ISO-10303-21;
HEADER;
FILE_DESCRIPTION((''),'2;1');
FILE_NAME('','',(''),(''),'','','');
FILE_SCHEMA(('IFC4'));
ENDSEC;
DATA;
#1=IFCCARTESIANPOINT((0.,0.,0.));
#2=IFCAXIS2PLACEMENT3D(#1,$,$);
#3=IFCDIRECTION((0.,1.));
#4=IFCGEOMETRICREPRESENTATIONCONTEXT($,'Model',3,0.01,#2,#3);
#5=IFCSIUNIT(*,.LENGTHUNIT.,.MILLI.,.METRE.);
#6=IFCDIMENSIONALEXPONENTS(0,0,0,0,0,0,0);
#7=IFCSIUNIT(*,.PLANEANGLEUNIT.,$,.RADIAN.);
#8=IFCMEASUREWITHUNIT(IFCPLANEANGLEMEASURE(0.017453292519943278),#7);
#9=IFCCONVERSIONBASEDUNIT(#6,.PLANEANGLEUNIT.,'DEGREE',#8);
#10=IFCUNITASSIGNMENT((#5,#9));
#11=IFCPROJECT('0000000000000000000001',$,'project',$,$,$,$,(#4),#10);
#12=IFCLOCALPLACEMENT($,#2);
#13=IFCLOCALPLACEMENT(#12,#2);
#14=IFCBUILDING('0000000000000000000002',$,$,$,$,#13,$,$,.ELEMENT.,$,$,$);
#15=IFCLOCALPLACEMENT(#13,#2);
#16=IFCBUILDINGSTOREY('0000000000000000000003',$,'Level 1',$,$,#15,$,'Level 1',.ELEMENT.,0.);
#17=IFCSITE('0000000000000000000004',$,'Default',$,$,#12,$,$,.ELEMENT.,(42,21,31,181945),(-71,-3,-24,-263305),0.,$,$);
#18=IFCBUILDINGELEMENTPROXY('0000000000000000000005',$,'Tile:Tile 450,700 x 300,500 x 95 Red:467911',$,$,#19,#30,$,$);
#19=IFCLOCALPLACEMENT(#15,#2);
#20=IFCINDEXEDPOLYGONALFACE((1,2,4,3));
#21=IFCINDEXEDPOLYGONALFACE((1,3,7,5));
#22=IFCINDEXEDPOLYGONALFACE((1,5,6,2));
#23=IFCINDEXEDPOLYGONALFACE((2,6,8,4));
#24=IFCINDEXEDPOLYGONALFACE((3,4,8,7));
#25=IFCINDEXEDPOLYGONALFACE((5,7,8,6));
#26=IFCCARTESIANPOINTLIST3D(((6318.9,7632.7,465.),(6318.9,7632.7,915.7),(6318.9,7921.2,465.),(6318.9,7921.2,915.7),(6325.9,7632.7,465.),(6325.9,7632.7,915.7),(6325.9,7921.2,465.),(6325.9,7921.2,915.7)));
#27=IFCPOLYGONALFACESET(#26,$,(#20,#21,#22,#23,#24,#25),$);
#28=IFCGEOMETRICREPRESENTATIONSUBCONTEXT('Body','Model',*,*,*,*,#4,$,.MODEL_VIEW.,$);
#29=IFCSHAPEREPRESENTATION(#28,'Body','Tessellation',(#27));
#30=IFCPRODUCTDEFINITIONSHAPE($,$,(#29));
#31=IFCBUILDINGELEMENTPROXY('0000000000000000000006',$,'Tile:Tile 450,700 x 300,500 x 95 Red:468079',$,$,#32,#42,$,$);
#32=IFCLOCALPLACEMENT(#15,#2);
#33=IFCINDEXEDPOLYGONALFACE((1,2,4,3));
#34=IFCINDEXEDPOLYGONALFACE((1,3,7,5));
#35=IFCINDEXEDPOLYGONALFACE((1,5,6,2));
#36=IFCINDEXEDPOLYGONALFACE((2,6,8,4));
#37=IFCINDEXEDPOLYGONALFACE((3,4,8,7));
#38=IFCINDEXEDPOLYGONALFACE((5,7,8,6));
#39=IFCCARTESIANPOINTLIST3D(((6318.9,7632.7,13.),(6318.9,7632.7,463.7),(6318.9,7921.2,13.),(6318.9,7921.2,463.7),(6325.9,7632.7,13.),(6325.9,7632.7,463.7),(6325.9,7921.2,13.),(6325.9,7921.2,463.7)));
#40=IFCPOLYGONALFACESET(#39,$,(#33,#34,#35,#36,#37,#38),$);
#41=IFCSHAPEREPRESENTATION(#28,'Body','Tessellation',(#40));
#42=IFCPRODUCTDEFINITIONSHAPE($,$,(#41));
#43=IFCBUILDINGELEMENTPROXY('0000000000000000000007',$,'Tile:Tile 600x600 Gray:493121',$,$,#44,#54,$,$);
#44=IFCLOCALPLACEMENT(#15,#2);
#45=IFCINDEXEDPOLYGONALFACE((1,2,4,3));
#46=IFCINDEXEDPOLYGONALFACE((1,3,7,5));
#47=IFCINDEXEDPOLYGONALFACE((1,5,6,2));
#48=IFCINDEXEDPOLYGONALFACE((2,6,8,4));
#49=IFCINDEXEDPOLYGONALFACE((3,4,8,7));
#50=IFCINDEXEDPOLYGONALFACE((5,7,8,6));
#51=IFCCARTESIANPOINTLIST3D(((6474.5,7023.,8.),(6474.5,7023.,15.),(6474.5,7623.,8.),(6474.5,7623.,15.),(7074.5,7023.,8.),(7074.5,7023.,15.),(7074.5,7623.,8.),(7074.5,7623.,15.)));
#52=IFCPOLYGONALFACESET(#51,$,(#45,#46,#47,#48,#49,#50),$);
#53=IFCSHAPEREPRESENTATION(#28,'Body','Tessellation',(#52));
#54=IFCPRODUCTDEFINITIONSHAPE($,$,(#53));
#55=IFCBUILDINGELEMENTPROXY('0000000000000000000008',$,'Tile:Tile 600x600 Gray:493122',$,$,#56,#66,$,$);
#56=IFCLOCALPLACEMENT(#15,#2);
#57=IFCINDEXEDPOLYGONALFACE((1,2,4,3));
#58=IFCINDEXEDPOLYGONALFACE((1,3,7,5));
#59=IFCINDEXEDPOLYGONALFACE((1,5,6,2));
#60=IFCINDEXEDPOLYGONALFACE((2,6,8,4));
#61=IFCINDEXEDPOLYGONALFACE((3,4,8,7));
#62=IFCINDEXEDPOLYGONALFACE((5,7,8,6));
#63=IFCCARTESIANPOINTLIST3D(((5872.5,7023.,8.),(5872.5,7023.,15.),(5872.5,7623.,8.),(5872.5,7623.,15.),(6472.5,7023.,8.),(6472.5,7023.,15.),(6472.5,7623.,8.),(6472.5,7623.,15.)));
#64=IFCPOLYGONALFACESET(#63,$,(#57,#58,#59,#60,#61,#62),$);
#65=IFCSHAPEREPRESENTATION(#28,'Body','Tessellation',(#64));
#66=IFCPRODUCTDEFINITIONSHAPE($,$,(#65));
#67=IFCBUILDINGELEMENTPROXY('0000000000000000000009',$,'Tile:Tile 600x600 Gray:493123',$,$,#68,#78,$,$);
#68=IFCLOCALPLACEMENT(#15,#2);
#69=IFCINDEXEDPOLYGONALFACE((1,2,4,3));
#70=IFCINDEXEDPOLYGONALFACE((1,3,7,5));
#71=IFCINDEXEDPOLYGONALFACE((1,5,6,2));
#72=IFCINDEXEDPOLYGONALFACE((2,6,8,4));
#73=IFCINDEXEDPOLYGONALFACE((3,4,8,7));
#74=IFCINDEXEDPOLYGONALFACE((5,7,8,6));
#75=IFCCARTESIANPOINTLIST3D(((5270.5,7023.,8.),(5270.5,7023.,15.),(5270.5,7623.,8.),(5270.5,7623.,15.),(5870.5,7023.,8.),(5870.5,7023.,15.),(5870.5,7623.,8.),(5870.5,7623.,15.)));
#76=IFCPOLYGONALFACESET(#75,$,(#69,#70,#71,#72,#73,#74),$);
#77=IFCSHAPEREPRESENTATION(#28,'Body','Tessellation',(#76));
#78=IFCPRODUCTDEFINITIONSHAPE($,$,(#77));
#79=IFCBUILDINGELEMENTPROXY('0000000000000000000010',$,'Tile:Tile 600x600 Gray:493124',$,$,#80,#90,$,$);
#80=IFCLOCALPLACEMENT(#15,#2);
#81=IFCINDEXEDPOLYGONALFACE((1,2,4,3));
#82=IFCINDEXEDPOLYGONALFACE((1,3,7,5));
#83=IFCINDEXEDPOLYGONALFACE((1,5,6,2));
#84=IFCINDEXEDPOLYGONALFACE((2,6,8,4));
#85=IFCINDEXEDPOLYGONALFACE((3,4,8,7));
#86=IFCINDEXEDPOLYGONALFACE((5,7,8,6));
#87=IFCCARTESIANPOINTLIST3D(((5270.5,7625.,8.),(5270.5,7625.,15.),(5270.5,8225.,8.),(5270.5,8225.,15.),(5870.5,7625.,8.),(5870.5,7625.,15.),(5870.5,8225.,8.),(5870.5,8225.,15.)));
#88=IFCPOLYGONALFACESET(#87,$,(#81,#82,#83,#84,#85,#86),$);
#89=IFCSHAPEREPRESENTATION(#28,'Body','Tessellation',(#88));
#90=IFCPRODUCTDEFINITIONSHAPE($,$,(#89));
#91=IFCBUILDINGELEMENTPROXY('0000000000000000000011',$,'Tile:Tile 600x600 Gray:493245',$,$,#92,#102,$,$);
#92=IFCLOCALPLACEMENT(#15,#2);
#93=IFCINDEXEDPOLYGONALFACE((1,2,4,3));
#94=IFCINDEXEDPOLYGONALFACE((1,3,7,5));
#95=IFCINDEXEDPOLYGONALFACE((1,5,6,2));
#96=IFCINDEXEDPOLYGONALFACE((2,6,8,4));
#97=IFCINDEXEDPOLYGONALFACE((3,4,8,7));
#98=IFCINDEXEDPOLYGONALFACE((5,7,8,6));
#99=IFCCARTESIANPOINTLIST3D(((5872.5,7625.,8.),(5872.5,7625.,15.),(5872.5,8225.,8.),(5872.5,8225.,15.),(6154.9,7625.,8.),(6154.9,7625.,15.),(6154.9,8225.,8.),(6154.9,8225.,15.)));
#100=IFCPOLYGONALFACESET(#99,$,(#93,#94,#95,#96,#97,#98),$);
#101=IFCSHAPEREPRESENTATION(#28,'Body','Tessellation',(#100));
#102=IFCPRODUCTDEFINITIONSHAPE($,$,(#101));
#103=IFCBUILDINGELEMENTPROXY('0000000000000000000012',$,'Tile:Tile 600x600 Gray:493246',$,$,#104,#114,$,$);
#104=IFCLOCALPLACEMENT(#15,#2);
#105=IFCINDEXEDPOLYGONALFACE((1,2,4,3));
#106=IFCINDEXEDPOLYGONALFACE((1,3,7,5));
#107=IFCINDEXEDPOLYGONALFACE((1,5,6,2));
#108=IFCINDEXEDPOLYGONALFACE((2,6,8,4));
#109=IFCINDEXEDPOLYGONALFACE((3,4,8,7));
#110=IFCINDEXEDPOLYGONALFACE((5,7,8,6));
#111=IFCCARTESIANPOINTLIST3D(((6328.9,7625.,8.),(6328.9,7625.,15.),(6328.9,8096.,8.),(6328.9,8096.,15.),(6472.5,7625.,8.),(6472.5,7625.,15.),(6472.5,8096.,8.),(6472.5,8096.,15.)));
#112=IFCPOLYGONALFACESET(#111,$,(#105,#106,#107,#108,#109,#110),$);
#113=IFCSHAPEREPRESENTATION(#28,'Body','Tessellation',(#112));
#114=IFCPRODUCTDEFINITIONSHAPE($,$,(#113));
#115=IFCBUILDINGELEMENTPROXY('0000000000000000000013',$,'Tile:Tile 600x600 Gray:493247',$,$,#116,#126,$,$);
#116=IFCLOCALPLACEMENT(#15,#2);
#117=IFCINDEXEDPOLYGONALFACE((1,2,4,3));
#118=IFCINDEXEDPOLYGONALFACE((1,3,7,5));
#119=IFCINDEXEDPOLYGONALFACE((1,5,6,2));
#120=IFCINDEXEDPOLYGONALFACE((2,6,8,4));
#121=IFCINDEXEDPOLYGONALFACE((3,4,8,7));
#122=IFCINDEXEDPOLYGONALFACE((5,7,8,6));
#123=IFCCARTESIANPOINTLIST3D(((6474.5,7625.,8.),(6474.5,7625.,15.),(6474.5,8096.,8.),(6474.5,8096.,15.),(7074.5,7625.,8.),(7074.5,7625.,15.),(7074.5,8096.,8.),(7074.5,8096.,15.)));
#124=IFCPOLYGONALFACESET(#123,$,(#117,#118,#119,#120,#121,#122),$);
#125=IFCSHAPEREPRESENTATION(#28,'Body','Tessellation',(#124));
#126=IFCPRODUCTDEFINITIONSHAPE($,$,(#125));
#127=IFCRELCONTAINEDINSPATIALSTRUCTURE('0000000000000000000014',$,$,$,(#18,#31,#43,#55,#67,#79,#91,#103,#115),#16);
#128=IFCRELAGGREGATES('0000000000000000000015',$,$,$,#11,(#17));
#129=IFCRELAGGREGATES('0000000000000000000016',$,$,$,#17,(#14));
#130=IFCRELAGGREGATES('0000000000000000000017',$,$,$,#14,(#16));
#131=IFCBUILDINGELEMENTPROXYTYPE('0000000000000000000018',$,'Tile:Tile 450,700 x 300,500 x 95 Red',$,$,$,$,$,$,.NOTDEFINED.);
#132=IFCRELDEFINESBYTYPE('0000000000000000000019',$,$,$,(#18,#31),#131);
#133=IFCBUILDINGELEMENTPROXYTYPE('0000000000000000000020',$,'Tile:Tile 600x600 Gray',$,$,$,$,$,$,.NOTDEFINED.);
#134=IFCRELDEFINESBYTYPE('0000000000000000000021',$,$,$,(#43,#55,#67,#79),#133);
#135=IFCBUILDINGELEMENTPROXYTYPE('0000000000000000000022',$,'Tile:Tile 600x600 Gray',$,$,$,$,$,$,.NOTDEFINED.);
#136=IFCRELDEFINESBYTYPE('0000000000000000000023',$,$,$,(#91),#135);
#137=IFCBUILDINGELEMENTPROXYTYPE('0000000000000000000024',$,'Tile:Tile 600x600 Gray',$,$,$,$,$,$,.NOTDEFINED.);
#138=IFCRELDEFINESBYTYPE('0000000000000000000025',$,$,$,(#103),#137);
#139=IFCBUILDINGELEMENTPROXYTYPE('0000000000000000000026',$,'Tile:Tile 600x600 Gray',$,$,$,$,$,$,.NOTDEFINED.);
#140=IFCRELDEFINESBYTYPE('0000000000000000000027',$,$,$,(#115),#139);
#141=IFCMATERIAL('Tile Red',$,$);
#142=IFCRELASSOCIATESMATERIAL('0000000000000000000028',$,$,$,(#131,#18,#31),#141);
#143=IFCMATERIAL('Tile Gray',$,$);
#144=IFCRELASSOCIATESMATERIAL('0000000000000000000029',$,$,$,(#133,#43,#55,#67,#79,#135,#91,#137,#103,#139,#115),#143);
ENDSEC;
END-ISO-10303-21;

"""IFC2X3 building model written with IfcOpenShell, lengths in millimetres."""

from ifc_helpers import new_model, entity, si_unit, converted_unit, direction, frame, frame_2d, origin, origin_2d_with_axis, place, context, subcontext, project, spatial, rectangle, extrude, source, transform, mapped, material, type_object, type_shapes, element, save


model = new_model("IFC2X3")

# Units and contexts
model_context = context("Model", 3, precision=0.01, world=origin(), true_north=direction((0.0, 1.0)))
body_context = subcontext(model_context, "Body", "Model", "MODEL_VIEW")
ifc_project = project(units=[si_unit("LENGTHUNIT", "METRE", prefix="MILLI"), converted_unit("PLANEANGLEUNIT", "DEGREE", entity("IfcPlaneAngleMeasure", 0.017453292519943278), si_unit("PLANEANGLEUNIT", "RADIAN"), dimensions=[0, 0, 0, 0, 0, 0, 0])], contexts=[model_context])

# Site, building, storey
site_placement = place(None, origin())
site = spatial("IfcSite", under=ifc_project, at=site_placement, Name="Default", CompositionType="ELEMENT", RefLatitude=(42, 21, 31, 181945), RefLongitude=(-71, -3, -24, -263305), RefElevation=0.0)
building_placement = place(site_placement, origin())
building = spatial("IfcBuilding", under=site, at=building_placement, CompositionType="ELEMENT")
storey_placement = place(building_placement, origin())
storey = spatial("IfcBuildingStorey", under=building, at=storey_placement, Name="Level 1", LongName="Level 1", CompositionType="ELEMENT", Elevation=0.0)

# Building element proxies
ifc_material_1 = material(Name="Tile Gray")
ifc_material_2 = material(Name="Tile Red")
building_element_proxy_type_1 = type_object("IfcBuildingElementProxyType", Name="Tile:Tile 450,700 x 300,500 x 95 Red", PredefinedType="NOTDEFINED", material=ifc_material_2)
shared_shape_1 = source(origin(), body_context, "Body", "SweptSolid", [
    extrude(rectangle(XDim=288.5, YDim=450.7, at=frame_2d((0.0, 0.0), x_axis=(1.0, 0.0))), frame((-144.2, -225.4, 0.0), z_axis=(0.0, 0.0, 1.0), x_axis=(-1.0, 0.0, 0.0)), (0.0, 0.0, 1.0), 7.0),
])
type_shapes(building_element_proxy_type_1, [shared_shape_1])
for number, where, z_axis, x_axis, name in (
    (1, (6318.9, 7632.7, 465.0), (1.0, 0.0, 0.0), (0.0, -1.0, 0.0), "Tile:Tile 450,700 x 300,500 x 95 Red:467911"),
    (2, (6318.9, 7632.7, 13.0), (1.0, 0.0, 0.0), (0.0, -1.0, 0.0), "Tile:Tile 450,700 x 300,500 x 95 Red:468079"),
):
    element("IfcBuildingElementProxy", number, at=place(storey_placement, frame(where, z_axis=z_axis, x_axis=x_axis)), inside=storey, type_object=building_element_proxy_type_1, material=ifc_material_2, Name=name, context=body_context, shape_type="MappedRepresentation", body=[
        mapped(shared_shape_1, transform((0.0, 0.0, 0.0), scale=1.0)),
    ])
building_element_proxy_type_2 = type_object("IfcBuildingElementProxyType", Name="Tile:Tile 600x600 Gray", PredefinedType="NOTDEFINED", material=ifc_material_1)
shared_shape_2 = source(origin(), body_context, "Body", "SweptSolid", [
    extrude(rectangle(XDim=600.0, YDim=600.0, at=frame_2d((0.0, 0.0), x_axis=(1.0, 0.0))), frame((-300.0, -300.0, 0.0), z_axis=(0.0, 0.0, 1.0), x_axis=(0.0, -1.0, 0.0)), (0.0, 0.0, 1.0), 7.0),
])
type_shapes(building_element_proxy_type_2, [shared_shape_2])
for number, where, z_axis, x_axis, name in (
    (3, (7074.5, 7023.0, 8.0), (0.0, 0.0, 1.0), (0.0, -1.0, 0.0), "Tile:Tile 600x600 Gray:493121"),
    (4, (6472.5, 7023.0, 8.0), (0.0, 0.0, 1.0), (0.0, -1.0, 0.0), "Tile:Tile 600x600 Gray:493122"),
    (5, (5870.5, 7023.0, 8.0), (0.0, 0.0, 1.0), (0.0, -1.0, 0.0), "Tile:Tile 600x600 Gray:493123"),
    (6, (5870.5, 7625.0, 8.0), (0.0, 0.0, 1.0), (0.0, -1.0, 0.0), "Tile:Tile 600x600 Gray:493124"),
):
    element("IfcBuildingElementProxy", number, at=place(storey_placement, frame(where, z_axis=z_axis, x_axis=x_axis)), inside=storey, type_object=building_element_proxy_type_2, material=ifc_material_1, Name=name, context=body_context, shape_type="MappedRepresentation", body=[
        mapped(shared_shape_2, transform((0.0, 0.0, 0.0), scale=1.0)),
    ])
building_element_proxy_type_3 = type_object("IfcBuildingElementProxyType", Name="Tile:Tile 600x600 Gray", PredefinedType="NOTDEFINED", material=ifc_material_1)
shared_shape_3 = source(origin(), body_context, "Body", "SweptSolid", [
    extrude(rectangle(XDim=282.4, YDim=600.0, at=frame_2d((0.0, 0.0), x_axis=(1.0, 0.0))), frame((-300.0, -141.2, 0.0), z_axis=(0.0, 0.0, 1.0), x_axis=(0.0, -1.0, 0.0)), (0.0, 0.0, 1.0), 7.0),
])
type_shapes(building_element_proxy_type_3, [shared_shape_3])
proxy_1_placement = place(storey_placement, frame((6154.9, 7625.0, 8.0), z_axis=(0.0, 0.0, 1.0), x_axis=(0.0, -1.0, 0.0)))
element("IfcBuildingElementProxy", 7, at=proxy_1_placement, inside=storey, type_object=building_element_proxy_type_3, material=ifc_material_1, Name="Tile:Tile 600x600 Gray:493245", context=body_context, shape_type="MappedRepresentation", body=[
    mapped(shared_shape_3, transform((0.0, 0.0, 0.0), scale=1.0)),
])
building_element_proxy_type_4 = type_object("IfcBuildingElementProxyType", Name="Tile:Tile 600x600 Gray", PredefinedType="NOTDEFINED", material=ifc_material_1)
shared_shape_4 = source(origin(), body_context, "Body", "SweptSolid", [
    extrude(rectangle(XDim=471.0, YDim=143.6, at=frame_2d((0.0, 0.0), x_axis=(1.0, 0.0))), frame((-235.5, -71.8, 0.0), z_axis=(0.0, 0.0, 1.0), x_axis=(-1.0, 0.0, 0.0)), (0.0, 0.0, 1.0), 7.0),
])
type_shapes(building_element_proxy_type_4, [shared_shape_4])
proxy_2_placement = place(storey_placement, frame((6472.5, 7625.0, 8.0), z_axis=(0.0, 0.0, 1.0), x_axis=(0.0, -1.0, 0.0)))
element("IfcBuildingElementProxy", 8, at=proxy_2_placement, inside=storey, type_object=building_element_proxy_type_4, material=ifc_material_1, Name="Tile:Tile 600x600 Gray:493246", context=body_context, shape_type="MappedRepresentation", body=[
    mapped(shared_shape_4, transform((0.0, 0.0, 0.0), scale=1.0)),
])
building_element_proxy_type_5 = type_object("IfcBuildingElementProxyType", Name="Tile:Tile 600x600 Gray", PredefinedType="NOTDEFINED", material=ifc_material_1)
shared_shape_5 = source(origin(), body_context, "Body", "SweptSolid", [
    extrude(rectangle(XDim=471.0, YDim=600.0, at=origin_2d_with_axis()), frame((-235.5, -300.0, 0.0), z_axis=(0.0, 0.0, 1.0), x_axis=(-1.0, 0.0, 0.0)), (0.0, 0.0, 1.0), 7.0),
])
type_shapes(building_element_proxy_type_5, [shared_shape_5])
proxy_3_placement = place(storey_placement, frame((7074.5, 7625.0, 8.0), z_axis=(0.0, 0.0, 1.0), x_axis=(0.0, -1.0, 0.0)))
element("IfcBuildingElementProxy", 9, at=proxy_3_placement, inside=storey, type_object=building_element_proxy_type_5, material=ifc_material_1, Name="Tile:Tile 600x600 Gray:493247", context=body_context, shape_type="MappedRepresentation", body=[
    mapped(shared_shape_5, transform((0.0, 0.0, 0.0), scale=1.0)),
])

save(model, "model.ifc")
